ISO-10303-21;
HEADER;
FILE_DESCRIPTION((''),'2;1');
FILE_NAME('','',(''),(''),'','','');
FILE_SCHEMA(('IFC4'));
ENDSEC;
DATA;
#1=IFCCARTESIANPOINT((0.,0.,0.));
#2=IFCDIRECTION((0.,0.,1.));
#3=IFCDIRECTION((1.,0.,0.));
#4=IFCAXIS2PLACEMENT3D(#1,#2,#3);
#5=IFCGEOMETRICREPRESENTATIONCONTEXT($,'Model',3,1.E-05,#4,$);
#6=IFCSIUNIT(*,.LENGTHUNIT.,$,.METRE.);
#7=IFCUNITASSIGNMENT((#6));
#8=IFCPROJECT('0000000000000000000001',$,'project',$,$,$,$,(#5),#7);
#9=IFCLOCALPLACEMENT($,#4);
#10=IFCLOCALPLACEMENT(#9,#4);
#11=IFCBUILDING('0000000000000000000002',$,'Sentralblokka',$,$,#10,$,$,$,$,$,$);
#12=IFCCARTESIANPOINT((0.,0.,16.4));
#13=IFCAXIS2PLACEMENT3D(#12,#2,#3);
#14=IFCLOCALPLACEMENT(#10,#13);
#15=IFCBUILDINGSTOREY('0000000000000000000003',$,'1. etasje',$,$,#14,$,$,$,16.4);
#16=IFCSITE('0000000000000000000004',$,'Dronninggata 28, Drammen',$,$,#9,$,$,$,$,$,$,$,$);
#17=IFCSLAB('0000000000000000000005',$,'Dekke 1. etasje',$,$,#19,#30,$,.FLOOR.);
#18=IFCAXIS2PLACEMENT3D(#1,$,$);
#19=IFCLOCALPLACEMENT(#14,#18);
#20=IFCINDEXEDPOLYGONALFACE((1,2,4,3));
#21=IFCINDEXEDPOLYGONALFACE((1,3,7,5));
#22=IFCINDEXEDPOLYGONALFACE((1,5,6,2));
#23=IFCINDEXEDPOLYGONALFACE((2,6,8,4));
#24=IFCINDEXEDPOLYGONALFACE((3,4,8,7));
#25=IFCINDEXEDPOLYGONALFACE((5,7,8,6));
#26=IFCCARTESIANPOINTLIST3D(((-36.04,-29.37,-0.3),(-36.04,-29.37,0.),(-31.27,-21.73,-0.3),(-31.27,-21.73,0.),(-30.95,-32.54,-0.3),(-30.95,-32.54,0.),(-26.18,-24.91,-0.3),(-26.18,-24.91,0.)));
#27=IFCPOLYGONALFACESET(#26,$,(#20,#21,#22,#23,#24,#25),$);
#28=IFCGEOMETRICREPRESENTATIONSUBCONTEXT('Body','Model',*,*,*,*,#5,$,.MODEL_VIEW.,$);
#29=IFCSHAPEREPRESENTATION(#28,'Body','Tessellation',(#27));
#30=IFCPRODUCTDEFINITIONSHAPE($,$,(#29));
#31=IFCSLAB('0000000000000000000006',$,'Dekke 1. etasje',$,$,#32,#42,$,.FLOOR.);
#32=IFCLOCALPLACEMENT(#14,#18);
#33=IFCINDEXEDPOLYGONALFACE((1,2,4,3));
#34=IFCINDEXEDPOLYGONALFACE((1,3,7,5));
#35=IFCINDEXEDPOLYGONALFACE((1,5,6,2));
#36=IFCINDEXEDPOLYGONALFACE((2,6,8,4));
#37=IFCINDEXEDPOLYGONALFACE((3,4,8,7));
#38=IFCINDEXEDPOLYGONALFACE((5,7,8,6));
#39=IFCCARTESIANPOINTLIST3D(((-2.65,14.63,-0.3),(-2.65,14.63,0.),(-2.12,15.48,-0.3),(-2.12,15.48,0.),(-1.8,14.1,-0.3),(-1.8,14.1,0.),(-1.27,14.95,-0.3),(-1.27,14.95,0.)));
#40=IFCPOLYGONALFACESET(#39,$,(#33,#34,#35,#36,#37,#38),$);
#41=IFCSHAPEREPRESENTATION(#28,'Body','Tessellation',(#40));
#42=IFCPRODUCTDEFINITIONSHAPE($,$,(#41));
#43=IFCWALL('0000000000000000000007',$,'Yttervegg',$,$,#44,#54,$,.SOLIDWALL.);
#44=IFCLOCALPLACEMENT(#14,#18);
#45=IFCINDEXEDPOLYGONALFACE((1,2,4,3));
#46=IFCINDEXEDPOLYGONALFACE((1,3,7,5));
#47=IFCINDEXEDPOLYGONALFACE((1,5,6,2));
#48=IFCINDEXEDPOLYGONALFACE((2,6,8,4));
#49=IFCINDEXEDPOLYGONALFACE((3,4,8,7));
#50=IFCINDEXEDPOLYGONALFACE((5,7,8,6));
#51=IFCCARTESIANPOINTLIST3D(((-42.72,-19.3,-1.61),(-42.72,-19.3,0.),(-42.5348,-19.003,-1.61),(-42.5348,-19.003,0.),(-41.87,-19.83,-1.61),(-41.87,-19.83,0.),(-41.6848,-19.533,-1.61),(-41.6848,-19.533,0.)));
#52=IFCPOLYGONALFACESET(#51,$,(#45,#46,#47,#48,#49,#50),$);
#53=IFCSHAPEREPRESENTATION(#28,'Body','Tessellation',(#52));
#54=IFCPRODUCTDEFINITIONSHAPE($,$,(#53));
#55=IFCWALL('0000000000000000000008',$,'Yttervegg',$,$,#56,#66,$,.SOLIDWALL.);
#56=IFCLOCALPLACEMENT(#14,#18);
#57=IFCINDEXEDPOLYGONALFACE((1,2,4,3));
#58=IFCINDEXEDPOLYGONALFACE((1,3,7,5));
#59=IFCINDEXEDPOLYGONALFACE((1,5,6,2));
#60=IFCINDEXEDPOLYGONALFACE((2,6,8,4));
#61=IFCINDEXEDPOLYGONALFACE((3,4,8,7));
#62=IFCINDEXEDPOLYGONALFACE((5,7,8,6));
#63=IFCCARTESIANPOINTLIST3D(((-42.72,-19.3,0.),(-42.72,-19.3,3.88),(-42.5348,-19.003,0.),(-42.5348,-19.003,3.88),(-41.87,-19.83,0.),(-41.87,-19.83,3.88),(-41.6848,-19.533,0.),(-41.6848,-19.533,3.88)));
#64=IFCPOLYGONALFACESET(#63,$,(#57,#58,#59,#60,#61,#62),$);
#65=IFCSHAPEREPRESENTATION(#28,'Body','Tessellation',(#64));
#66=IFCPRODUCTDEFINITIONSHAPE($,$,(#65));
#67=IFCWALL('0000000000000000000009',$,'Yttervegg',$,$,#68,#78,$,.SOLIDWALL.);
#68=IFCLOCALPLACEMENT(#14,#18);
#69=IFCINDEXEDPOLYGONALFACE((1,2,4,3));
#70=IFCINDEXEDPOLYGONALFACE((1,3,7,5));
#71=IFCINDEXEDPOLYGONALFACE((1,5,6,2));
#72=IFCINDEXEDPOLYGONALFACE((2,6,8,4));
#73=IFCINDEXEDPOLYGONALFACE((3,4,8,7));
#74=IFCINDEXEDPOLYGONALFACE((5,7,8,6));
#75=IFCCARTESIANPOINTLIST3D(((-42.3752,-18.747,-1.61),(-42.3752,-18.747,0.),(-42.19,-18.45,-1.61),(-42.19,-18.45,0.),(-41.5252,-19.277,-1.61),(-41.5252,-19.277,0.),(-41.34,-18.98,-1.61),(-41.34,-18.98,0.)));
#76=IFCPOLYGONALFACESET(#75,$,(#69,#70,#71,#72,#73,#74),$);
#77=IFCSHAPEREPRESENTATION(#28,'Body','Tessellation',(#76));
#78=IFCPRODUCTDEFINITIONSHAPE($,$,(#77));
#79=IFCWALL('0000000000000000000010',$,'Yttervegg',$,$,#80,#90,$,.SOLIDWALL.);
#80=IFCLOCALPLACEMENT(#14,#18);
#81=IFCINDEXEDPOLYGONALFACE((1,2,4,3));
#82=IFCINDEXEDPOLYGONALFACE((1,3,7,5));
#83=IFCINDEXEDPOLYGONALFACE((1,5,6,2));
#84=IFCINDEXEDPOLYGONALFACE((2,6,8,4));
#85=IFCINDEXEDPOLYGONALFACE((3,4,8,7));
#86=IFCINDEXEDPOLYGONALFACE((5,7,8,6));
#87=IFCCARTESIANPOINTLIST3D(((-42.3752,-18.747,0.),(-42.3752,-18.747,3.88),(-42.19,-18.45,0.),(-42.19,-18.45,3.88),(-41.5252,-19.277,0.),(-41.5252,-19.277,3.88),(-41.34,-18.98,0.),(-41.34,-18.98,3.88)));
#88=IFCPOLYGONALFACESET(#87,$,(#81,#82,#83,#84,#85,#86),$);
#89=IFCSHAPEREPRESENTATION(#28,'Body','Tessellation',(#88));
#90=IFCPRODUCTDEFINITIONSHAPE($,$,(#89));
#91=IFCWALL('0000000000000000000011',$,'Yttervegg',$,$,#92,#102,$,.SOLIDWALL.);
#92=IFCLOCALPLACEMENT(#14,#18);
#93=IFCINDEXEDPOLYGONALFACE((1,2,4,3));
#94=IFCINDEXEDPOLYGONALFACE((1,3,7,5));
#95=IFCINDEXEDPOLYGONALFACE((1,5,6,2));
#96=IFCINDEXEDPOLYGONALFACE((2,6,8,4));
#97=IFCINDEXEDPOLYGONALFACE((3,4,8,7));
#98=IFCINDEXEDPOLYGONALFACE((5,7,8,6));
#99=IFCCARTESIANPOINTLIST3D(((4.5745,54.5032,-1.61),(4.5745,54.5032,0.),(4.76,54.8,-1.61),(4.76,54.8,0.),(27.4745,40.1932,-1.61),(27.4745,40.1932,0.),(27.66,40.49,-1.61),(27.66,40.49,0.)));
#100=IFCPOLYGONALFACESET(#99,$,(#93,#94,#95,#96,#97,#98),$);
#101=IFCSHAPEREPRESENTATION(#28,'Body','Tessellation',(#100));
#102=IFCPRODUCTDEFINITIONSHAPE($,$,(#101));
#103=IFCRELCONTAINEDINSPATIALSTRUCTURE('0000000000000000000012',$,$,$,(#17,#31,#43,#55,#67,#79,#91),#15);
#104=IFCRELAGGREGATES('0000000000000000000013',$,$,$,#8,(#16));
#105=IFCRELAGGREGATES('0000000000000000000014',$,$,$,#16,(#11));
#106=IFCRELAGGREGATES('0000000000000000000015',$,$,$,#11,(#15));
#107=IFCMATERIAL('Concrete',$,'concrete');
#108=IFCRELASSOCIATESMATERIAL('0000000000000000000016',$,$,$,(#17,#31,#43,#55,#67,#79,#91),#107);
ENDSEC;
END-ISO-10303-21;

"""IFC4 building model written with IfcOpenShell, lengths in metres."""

from ifc_helpers import new_model, si_unit, frame, origin_with_axes, place, context, subcontext, project, spatial, polyline, outline, extrude, material, element, save


model = new_model("IFC4")

# Units and contexts
model_context = context("Model", 3, precision=1e-05, world=origin_with_axes())
body_context = subcontext(model_context, "Body", "Model", "MODEL_VIEW")
ifc_project = project(units=[si_unit("LENGTHUNIT", "METRE")], contexts=[model_context])

# Site, building, storey
site_placement = place(None, origin_with_axes())
site = spatial("IfcSite", under=ifc_project, at=site_placement, Name="Dronninggata 28, Drammen")
building_placement = place(site_placement, origin_with_axes())
building = spatial("IfcBuilding", under=site, at=building_placement, Name="Sentralblokka")
storey_placement = place(building_placement, frame((0.0, 0.0, 16.4), z_axis=(0.0, 0.0, 1.0), x_axis=(1.0, 0.0, 0.0)))
storey = spatial("IfcBuildingStorey", under=building, at=storey_placement, Name="1. etasje", Elevation=16.4)

# Slabs
ifc_material_1 = material(Name="Concrete", Category="concrete")
slab_1_placement = place(storey_placement, frame((0.0, 0.0, -16.4), z_axis=(0.0, 0.0, 1.0), x_axis=(1.0, 0.0, 0.0)))
element("IfcSlab", 1, at=slab_1_placement, inside=storey, material=ifc_material_1, Name="Dekke 1. etasje", PredefinedType="FLOOR", context=body_context, shape_type="SweptSolid", body=[
    extrude(outline(polyline([(-30.95, -32.54), (-26.18, -24.91), (-31.27, -21.73), (-36.04, -29.37), (-30.95, -32.54)])), frame((0.0, 0.0, 16.1)), (0.0, 0.0, 1.0), 0.3),
])
slab_2_placement = place(storey_placement, frame((0.0, 0.0, -16.4), z_axis=(0.0, 0.0, 1.0), x_axis=(1.0, 0.0, 0.0)))
element("IfcSlab", 2, at=slab_2_placement, inside=storey, material=ifc_material_1, Name="Dekke 1. etasje", PredefinedType="FLOOR", context=body_context, shape_type="SweptSolid", body=[
    extrude(outline(polyline([(-1.8, 14.1), (-1.27, 14.95), (-2.12, 15.48), (-2.65, 14.63), (-1.8, 14.1)])), frame((0.0, 0.0, 16.1)), (0.0, 0.0, 1.0), 0.3),
])

# Walls
wall_1_placement = place(storey_placement, frame((0.0, 0.0, -16.4), z_axis=(0.0, 0.0, 1.0), x_axis=(1.0, 0.0, 0.0)))
element("IfcWall", 3, at=wall_1_placement, inside=storey, material=ifc_material_1, Name="Yttervegg", PredefinedType="SOLIDWALL", context=body_context, shape_type="SweptSolid", body=[
    extrude(outline(polyline([(-41.87, -19.83), (-42.72, -19.3), (-42.5348, -19.003), (-41.6848, -19.533), (-41.87, -19.83)])), frame((0.0, 0.0, 14.79)), (0.0, 0.0, 1.0), 1.61),
])
wall_2_placement = place(storey_placement, frame((0.0, 0.0, -16.4), z_axis=(0.0, 0.0, 1.0), x_axis=(1.0, 0.0, 0.0)))
element("IfcWall", 4, at=wall_2_placement, inside=storey, material=ifc_material_1, Name="Yttervegg", PredefinedType="SOLIDWALL", context=body_context, shape_type="SweptSolid", body=[
    extrude(outline(polyline([(-41.87, -19.83), (-42.72, -19.3), (-42.5348, -19.003), (-41.6848, -19.533), (-41.87, -19.83)])), frame((0.0, 0.0, 16.4)), (0.0, 0.0, 1.0), 3.88),
])
wall_3_placement = place(storey_placement, frame((0.0, 0.0, -16.4), z_axis=(0.0, 0.0, 1.0), x_axis=(1.0, 0.0, 0.0)))
element("IfcWall", 5, at=wall_3_placement, inside=storey, material=ifc_material_1, Name="Yttervegg", PredefinedType="SOLIDWALL", context=body_context, shape_type="SweptSolid", body=[
    extrude(outline(polyline([(-42.19, -18.45), (-41.34, -18.98), (-41.5252, -19.277), (-42.3752, -18.747), (-42.19, -18.45)])), frame((0.0, 0.0, 14.79)), (0.0, 0.0, 1.0), 1.61),
])
wall_4_placement = place(storey_placement, frame((0.0, 0.0, -16.4), z_axis=(0.0, 0.0, 1.0), x_axis=(1.0, 0.0, 0.0)))
element("IfcWall", 6, at=wall_4_placement, inside=storey, material=ifc_material_1, Name="Yttervegg", PredefinedType="SOLIDWALL", context=body_context, shape_type="SweptSolid", body=[
    extrude(outline(polyline([(-42.19, -18.45), (-41.34, -18.98), (-41.5252, -19.277), (-42.3752, -18.747), (-42.19, -18.45)])), frame((0.0, 0.0, 16.4)), (0.0, 0.0, 1.0), 3.88),
])
wall_5_placement = place(storey_placement, frame((0.0, 0.0, -16.4), z_axis=(0.0, 0.0, 1.0), x_axis=(1.0, 0.0, 0.0)))
element("IfcWall", 7, at=wall_5_placement, inside=storey, material=ifc_material_1, Name="Yttervegg", PredefinedType="SOLIDWALL", context=body_context, shape_type="SweptSolid", body=[
    extrude(outline(polyline([(4.76, 54.8), (27.66, 40.49), (27.4745, 40.1932), (4.5745, 54.5032), (4.76, 54.8)])), frame((0.0, 0.0, 14.79)), (0.0, 0.0, 1.0), 1.61),
])

save(model, "model.ifc")
